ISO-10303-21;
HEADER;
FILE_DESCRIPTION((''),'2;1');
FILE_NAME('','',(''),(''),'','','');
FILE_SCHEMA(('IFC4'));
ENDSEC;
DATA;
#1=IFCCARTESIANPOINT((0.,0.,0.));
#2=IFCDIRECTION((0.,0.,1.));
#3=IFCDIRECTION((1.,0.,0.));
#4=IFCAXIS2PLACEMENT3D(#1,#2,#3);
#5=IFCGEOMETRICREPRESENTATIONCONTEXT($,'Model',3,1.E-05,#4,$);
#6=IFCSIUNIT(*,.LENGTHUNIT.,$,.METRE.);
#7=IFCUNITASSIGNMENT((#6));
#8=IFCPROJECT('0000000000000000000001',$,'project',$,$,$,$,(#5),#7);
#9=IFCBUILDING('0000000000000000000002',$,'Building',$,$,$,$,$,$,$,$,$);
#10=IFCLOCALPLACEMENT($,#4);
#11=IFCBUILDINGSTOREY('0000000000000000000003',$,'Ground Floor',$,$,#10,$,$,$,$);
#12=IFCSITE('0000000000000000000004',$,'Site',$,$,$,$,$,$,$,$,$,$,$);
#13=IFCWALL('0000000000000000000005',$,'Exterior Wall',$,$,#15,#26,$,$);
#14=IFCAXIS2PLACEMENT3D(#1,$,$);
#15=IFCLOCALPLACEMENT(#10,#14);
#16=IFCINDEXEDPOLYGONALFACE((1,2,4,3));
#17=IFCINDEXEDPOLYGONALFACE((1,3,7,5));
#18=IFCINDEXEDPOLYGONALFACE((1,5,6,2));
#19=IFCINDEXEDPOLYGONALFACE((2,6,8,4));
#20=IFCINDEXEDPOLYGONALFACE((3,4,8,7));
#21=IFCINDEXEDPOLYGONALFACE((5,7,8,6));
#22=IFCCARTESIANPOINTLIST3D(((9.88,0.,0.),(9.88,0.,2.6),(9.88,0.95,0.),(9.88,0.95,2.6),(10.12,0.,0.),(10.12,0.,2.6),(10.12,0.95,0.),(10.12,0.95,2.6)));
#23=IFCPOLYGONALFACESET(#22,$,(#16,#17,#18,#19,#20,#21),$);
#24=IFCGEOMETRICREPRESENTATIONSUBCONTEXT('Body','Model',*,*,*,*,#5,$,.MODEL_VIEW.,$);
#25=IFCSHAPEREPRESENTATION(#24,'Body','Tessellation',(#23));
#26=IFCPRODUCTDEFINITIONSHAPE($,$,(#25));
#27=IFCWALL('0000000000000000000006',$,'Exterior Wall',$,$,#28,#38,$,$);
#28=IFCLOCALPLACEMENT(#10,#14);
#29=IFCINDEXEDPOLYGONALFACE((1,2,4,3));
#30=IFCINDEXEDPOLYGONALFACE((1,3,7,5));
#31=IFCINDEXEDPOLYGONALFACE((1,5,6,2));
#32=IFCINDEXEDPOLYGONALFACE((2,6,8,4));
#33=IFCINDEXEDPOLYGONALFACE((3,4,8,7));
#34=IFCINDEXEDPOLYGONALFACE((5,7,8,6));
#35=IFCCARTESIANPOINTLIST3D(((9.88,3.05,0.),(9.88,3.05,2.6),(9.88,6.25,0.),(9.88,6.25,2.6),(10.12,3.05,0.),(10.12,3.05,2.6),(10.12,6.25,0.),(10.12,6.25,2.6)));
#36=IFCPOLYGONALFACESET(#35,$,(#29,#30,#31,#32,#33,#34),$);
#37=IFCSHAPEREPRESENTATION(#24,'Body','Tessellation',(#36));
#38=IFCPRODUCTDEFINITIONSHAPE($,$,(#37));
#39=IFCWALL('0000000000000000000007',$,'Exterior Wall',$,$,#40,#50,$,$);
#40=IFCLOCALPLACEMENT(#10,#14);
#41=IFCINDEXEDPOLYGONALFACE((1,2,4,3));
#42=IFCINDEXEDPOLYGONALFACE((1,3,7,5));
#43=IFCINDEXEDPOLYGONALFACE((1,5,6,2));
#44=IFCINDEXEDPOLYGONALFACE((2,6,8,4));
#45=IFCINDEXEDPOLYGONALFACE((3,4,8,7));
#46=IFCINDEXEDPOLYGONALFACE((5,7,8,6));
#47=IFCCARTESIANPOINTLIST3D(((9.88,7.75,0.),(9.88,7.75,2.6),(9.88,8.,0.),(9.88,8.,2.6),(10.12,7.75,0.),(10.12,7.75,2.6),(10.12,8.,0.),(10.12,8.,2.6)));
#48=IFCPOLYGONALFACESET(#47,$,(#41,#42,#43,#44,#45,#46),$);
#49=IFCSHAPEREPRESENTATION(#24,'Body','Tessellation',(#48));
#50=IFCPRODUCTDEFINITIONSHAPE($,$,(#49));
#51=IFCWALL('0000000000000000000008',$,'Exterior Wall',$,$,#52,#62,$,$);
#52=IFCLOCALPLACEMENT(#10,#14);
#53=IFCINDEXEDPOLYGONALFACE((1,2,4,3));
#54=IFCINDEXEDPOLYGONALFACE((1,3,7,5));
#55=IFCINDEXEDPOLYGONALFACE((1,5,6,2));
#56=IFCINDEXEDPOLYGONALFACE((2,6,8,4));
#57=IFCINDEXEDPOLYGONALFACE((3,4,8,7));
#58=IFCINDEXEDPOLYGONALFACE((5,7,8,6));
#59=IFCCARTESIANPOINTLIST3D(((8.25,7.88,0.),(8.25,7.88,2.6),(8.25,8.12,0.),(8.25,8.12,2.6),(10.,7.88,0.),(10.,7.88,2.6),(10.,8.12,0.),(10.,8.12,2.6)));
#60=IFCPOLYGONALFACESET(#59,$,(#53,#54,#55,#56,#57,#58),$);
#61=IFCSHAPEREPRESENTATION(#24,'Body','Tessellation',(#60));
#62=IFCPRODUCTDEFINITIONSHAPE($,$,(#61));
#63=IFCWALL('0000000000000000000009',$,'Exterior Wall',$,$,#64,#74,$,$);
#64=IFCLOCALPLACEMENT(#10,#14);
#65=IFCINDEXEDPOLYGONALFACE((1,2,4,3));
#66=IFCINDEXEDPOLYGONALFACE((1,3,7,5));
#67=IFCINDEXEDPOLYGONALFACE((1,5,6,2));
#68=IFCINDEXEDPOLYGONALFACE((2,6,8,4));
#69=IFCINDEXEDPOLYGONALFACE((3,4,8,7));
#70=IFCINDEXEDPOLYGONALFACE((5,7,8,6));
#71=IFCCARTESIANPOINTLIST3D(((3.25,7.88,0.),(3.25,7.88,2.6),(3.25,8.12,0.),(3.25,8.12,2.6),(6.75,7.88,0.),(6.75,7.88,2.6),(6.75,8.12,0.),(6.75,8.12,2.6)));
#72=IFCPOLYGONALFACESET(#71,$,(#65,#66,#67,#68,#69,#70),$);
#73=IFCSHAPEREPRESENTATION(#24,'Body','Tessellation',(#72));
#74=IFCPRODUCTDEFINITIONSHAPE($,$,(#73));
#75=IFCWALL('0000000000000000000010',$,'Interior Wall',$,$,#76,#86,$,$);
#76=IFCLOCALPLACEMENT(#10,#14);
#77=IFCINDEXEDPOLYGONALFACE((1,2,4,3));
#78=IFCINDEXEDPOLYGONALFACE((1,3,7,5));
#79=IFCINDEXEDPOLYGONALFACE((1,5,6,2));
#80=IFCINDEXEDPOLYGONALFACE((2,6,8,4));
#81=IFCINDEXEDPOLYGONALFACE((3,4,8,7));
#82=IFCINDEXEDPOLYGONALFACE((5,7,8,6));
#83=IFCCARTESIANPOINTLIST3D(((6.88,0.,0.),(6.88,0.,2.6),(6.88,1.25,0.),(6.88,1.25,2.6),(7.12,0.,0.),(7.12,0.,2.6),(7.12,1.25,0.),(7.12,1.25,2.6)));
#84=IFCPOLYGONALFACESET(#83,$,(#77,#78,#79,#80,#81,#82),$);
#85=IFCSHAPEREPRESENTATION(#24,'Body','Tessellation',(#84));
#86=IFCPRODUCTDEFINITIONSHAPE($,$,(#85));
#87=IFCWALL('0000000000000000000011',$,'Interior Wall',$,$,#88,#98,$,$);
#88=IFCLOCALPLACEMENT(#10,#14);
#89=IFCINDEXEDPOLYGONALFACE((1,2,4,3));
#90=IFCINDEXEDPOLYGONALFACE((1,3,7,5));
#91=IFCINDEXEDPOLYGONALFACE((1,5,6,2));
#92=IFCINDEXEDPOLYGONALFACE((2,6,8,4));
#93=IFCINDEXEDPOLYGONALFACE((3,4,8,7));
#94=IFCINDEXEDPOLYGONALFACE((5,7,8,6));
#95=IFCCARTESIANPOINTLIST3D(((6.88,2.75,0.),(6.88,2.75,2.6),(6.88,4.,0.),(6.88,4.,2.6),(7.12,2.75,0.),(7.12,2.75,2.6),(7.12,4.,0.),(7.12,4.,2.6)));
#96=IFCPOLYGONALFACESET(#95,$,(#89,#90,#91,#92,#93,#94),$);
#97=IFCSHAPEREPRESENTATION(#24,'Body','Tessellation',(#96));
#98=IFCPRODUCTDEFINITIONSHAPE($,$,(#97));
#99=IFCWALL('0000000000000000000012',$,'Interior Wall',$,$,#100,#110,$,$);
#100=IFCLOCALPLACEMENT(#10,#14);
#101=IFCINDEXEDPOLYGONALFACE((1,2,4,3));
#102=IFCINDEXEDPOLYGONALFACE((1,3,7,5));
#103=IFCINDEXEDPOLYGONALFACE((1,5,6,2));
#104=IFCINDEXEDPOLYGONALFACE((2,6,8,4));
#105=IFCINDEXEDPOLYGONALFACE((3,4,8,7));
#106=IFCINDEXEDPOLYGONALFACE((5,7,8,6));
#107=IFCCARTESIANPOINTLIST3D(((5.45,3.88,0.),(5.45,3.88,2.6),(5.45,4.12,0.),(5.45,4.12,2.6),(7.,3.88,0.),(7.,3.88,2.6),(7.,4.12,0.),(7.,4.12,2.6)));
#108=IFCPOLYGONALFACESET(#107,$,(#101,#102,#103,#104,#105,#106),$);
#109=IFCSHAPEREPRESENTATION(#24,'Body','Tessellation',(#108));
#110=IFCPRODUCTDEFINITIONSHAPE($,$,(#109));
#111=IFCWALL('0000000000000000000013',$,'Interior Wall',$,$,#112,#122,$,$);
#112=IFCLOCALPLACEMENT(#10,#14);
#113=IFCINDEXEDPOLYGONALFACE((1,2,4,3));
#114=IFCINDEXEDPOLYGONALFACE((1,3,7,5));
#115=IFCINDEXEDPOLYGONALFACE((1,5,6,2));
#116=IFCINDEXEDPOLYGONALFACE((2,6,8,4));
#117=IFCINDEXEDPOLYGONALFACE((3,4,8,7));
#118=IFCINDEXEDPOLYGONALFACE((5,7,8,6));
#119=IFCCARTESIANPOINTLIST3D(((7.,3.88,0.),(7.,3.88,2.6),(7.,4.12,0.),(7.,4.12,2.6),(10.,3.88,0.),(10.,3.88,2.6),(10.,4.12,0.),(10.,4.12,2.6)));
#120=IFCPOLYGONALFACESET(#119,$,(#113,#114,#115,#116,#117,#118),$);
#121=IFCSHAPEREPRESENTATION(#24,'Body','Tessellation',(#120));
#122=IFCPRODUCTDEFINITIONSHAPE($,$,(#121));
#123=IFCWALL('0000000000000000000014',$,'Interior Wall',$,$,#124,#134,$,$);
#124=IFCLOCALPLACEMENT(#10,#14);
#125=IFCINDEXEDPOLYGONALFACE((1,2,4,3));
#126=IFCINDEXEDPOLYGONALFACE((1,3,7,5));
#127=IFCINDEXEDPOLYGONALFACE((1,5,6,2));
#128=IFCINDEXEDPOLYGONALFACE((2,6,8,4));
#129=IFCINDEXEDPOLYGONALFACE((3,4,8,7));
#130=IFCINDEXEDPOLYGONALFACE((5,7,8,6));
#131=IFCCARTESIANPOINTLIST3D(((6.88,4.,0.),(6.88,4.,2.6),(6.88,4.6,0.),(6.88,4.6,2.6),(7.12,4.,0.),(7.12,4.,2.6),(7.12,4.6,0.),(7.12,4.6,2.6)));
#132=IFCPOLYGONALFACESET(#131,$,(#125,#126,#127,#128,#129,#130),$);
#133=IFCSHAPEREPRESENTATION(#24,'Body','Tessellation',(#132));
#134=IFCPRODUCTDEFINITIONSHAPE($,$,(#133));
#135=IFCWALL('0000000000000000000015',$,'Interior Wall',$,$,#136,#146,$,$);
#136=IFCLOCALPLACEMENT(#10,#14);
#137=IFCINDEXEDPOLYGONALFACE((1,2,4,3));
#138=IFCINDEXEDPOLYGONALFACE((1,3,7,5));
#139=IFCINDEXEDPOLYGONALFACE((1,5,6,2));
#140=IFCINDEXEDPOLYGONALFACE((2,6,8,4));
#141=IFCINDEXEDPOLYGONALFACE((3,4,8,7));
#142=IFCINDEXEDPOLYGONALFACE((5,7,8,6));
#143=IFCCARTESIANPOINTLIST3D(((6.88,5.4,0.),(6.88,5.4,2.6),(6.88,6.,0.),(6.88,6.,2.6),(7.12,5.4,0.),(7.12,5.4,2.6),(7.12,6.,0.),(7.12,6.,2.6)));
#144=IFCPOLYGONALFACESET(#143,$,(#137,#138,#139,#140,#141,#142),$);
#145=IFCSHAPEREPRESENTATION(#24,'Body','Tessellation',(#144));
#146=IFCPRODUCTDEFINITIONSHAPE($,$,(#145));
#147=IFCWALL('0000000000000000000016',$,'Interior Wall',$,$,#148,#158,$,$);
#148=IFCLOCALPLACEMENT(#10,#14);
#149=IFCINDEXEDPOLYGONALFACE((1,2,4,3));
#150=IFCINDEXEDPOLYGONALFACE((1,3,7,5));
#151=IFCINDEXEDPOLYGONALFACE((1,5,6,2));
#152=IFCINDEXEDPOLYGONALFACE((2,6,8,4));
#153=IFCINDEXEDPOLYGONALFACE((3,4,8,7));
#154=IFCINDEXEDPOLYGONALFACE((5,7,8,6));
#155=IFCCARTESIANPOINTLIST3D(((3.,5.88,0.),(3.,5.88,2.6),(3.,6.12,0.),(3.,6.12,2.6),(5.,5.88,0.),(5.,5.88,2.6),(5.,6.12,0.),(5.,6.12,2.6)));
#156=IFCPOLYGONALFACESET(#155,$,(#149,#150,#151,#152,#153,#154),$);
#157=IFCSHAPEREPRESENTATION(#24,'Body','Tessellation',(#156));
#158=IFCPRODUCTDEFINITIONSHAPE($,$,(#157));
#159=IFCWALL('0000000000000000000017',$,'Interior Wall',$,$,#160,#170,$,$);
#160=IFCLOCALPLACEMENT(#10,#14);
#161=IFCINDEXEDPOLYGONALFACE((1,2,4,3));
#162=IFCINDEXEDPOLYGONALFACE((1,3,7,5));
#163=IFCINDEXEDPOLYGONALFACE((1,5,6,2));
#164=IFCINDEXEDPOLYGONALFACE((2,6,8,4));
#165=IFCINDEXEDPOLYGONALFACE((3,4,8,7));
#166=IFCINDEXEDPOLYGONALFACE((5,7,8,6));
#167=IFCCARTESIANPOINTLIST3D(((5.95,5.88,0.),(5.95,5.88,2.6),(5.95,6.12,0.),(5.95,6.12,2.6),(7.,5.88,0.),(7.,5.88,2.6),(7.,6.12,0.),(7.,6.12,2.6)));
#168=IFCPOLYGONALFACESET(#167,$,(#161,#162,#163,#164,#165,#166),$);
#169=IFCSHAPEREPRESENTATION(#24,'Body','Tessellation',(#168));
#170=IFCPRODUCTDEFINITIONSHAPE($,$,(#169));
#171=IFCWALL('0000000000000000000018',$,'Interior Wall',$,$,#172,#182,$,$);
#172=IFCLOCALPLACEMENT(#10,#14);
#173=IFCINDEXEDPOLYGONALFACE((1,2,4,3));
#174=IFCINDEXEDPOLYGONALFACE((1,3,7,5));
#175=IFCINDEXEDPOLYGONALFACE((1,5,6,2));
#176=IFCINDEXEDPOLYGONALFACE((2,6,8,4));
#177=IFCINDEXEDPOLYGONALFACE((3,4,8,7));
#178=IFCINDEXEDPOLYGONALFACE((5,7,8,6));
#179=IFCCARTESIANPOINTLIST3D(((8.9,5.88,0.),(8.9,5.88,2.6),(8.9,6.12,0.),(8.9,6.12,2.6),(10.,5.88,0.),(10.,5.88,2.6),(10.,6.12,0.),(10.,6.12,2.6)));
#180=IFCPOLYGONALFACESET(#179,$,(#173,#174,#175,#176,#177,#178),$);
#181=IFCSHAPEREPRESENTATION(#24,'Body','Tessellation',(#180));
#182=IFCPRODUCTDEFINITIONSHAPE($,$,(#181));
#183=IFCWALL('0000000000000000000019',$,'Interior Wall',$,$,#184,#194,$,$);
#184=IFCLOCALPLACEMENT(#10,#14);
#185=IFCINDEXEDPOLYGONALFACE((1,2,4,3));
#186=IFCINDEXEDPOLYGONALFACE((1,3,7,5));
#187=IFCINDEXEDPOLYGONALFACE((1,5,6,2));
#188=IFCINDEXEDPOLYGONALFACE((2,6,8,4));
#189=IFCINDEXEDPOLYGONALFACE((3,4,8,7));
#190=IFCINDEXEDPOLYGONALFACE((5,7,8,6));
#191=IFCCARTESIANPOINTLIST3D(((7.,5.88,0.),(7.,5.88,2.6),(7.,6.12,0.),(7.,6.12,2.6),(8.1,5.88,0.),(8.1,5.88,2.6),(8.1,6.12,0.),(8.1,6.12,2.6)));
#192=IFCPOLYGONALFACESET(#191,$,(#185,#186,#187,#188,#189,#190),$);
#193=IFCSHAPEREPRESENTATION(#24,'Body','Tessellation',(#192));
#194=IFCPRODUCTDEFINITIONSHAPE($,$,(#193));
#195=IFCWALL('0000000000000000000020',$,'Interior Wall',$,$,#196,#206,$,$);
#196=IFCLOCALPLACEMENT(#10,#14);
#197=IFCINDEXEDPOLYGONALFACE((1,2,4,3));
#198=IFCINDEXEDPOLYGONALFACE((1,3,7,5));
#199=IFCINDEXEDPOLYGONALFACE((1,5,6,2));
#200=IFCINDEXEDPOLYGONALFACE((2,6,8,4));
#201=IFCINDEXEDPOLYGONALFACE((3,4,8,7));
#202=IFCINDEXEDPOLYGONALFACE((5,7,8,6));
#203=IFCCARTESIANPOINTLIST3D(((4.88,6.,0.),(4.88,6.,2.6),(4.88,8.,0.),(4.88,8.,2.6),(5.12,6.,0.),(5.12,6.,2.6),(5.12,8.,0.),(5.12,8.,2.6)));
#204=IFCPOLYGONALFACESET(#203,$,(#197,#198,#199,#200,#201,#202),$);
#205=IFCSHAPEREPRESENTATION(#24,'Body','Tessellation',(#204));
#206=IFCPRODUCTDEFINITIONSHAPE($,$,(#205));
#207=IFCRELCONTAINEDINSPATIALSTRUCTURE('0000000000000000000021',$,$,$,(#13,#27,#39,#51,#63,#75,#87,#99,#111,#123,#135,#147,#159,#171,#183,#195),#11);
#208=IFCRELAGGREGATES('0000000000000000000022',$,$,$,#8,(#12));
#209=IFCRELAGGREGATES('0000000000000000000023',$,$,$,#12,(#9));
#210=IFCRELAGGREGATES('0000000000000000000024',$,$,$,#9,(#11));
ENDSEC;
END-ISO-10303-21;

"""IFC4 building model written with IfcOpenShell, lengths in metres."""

from ifc_helpers import new_model, si_unit, frame, origin_with_axes, place, context, subcontext, project, spatial, indexed_curve, outline, extrude, element, save


model = new_model("IFC4")

# Units and contexts
model_context = context("Model", 3, precision=1e-05, world=origin_with_axes())
body_context = subcontext(model_context, "Body", "Model", "MODEL_VIEW")
ifc_project = project(units=[si_unit("LENGTHUNIT", "METRE")], contexts=[model_context])

# Site, building, storey
site = spatial("IfcSite", under=ifc_project, Name="Site")
building = spatial("IfcBuilding", under=site, Name="Building")
storey_placement = place(None, origin_with_axes())
storey = spatial("IfcBuildingStorey", under=building, at=storey_placement, Name="Ground Floor")

# Walls
wall_1_placement = place(storey_placement, frame((10.0, 0.0, 0.0), z_axis=(0.0, 0.0, 1.0), x_axis=(0.0, 1.0, 0.0)))
element("IfcWall", 1, at=wall_1_placement, inside=storey, Name="Exterior Wall", context=body_context, shape_type="SweptSolid", body=[
    extrude(outline(indexed_curve([(0.0, 0.0), (0.0, 0.24), (0.95, 0.24), (0.95, 0.0), (0.0, 0.0)], self_intersect=False)), frame((0.0, -0.12, 0.0), z_axis=(0.0, 0.0, 1.0), x_axis=(1.0, 0.0, 0.0)), (0.0, 0.0, 1.0), 2.6),
])
wall_2_placement = place(storey_placement, frame((10.0, 3.05, 0.0), z_axis=(0.0, 0.0, 1.0), x_axis=(0.0, 1.0, 0.0)))
element("IfcWall", 2, at=wall_2_placement, inside=storey, Name="Exterior Wall", context=body_context, shape_type="SweptSolid", body=[
    extrude(outline(indexed_curve([(0.0, 0.0), (0.0, 0.24), (3.2, 0.24), (3.2, 0.0), (0.0, 0.0)], self_intersect=False)), frame((0.0, -0.12, 0.0), z_axis=(0.0, 0.0, 1.0), x_axis=(1.0, 0.0, 0.0)), (0.0, 0.0, 1.0), 2.6),
])
wall_3_placement = place(storey_placement, frame((10.0, 7.75, 0.0), z_axis=(0.0, 0.0, 1.0), x_axis=(0.0, 1.0, 0.0)))
element("IfcWall", 3, at=wall_3_placement, inside=storey, Name="Exterior Wall", context=body_context, shape_type="SweptSolid", body=[
    extrude(outline(indexed_curve([(0.0, 0.0), (0.0, 0.24), (0.25, 0.24), (0.25, 0.0), (0.0, 0.0)], self_intersect=False)), frame((0.0, -0.12, 0.0), z_axis=(0.0, 0.0, 1.0), x_axis=(1.0, 0.0, 0.0)), (0.0, 0.0, 1.0), 2.6),
])
wall_4_placement = place(storey_placement, frame((10.0, 8.0, 0.0), z_axis=(0.0, 0.0, 1.0), x_axis=(-1.0, 0.0, 0.0)))
element("IfcWall", 4, at=wall_4_placement, inside=storey, Name="Exterior Wall", context=body_context, shape_type="SweptSolid", body=[
    extrude(outline(indexed_curve([(0.0, 0.0), (0.0, 0.24), (1.75, 0.24), (1.75, 0.0), (0.0, 0.0)], self_intersect=False)), frame((0.0, -0.12, 0.0), z_axis=(0.0, 0.0, 1.0), x_axis=(1.0, 0.0, 0.0)), (0.0, 0.0, 1.0), 2.6),
])
wall_5_placement = place(storey_placement, frame((6.75, 8.0, 0.0), z_axis=(0.0, 0.0, 1.0), x_axis=(-1.0, 0.0, 0.0)))
element("IfcWall", 5, at=wall_5_placement, inside=storey, Name="Exterior Wall", context=body_context, shape_type="SweptSolid", body=[
    extrude(outline(indexed_curve([(0.0, 0.0), (0.0, 0.24), (3.5, 0.24), (3.5, 0.0), (0.0, 0.0)], self_intersect=False)), frame((0.0, -0.12, 0.0), z_axis=(0.0, 0.0, 1.0), x_axis=(1.0, 0.0, 0.0)), (0.0, 0.0, 1.0), 2.6),
])
for number, where, z_axis, x_axis, name in (
    (6, (7.0, 0.0, 0.0), (0.0, 0.0, 1.0), (0.0, 1.0, 0.0), "Interior Wall"),
    (7, (7.0, 2.75, 0.0), (0.0, 0.0, 1.0), (0.0, 1.0, 0.0), "Interior Wall"),
):
    element("IfcWall", number, at=place(storey_placement, frame(where, z_axis=z_axis, x_axis=x_axis)), inside=storey, Name=name, context=body_context, shape_type="SweptSolid", body=[
        extrude(outline(indexed_curve([(0.0, 0.0), (0.0, 0.24), (1.25, 0.24), (1.25, 0.0), (0.0, 0.0)], self_intersect=False)), frame((0.0, -0.12, 0.0), z_axis=(0.0, 0.0, 1.0), x_axis=(1.0, 0.0, 0.0)), (0.0, 0.0, 1.0), 2.6),
    ])
wall_6_placement = place(storey_placement, frame((7.0, 4.0, 0.0), z_axis=(0.0, 0.0, 1.0), x_axis=(-1.0, 0.0, 0.0)))
element("IfcWall", 8, at=wall_6_placement, inside=storey, Name="Interior Wall", context=body_context, shape_type="SweptSolid", body=[
    extrude(outline(indexed_curve([(0.0, 0.0), (0.0, 0.24), (1.55, 0.24), (1.55, 0.0), (0.0, 0.0)], self_intersect=False)), frame((0.0, -0.12, 0.0), z_axis=(0.0, 0.0, 1.0), x_axis=(1.0, 0.0, 0.0)), (0.0, 0.0, 1.0), 2.6),
])
wall_7_placement = place(storey_placement, frame((10.0, 4.0, 0.0), z_axis=(0.0, 0.0, 1.0), x_axis=(-1.0, 0.0, 0.0)))
element("IfcWall", 9, at=wall_7_placement, inside=storey, Name="Interior Wall", context=body_context, shape_type="SweptSolid", body=[
    extrude(outline(indexed_curve([(0.0, 0.0), (0.0, 0.24), (3.0, 0.24), (3.0, 0.0), (0.0, 0.0)], self_intersect=False)), frame((0.0, -0.12, 0.0), z_axis=(0.0, 0.0, 1.0), x_axis=(1.0, 0.0, 0.0)), (0.0, 0.0, 1.0), 2.6),
])
for number, where, z_axis, x_axis, name in (
    (10, (7.0, 4.0, 0.0), (0.0, 0.0, 1.0), (0.0, 1.0, 0.0), "Interior Wall"),
    (11, (7.0, 5.4, 0.0), (0.0, 0.0, 1.0), (0.0, 1.0, 0.0), "Interior Wall"),
):
    element("IfcWall", number, at=place(storey_placement, frame(where, z_axis=z_axis, x_axis=x_axis)), inside=storey, Name=name, context=body_context, shape_type="SweptSolid", body=[
        extrude(outline(indexed_curve([(0.0, 0.0), (0.0, 0.24), (0.6, 0.24), (0.6, 0.0), (0.0, 0.0)], self_intersect=False)), frame((0.0, -0.12, 0.0), z_axis=(0.0, 0.0, 1.0), x_axis=(1.0, 0.0, 0.0)), (0.0, 0.0, 1.0), 2.6),
    ])
wall_8_placement = place(storey_placement, frame((5.0, 6.0, 0.0), z_axis=(0.0, 0.0, 1.0), x_axis=(-1.0, 0.0, 0.0)))
element("IfcWall", 12, at=wall_8_placement, inside=storey, Name="Interior Wall", context=body_context, shape_type="SweptSolid", body=[
    extrude(outline(indexed_curve([(0.0, 0.0), (0.0, 0.24), (2.0, 0.24), (2.0, 0.0), (0.0, 0.0)], self_intersect=False)), frame((0.0, -0.12, 0.0), z_axis=(0.0, 0.0, 1.0), x_axis=(1.0, 0.0, 0.0)), (0.0, 0.0, 1.0), 2.6),
])
wall_9_placement = place(storey_placement, frame((7.0, 6.0, 0.0), z_axis=(0.0, 0.0, 1.0), x_axis=(-1.0, 0.0, 0.0)))
element("IfcWall", 13, at=wall_9_placement, inside=storey, Name="Interior Wall", context=body_context, shape_type="SweptSolid", body=[
    extrude(outline(indexed_curve([(0.0, 0.0), (0.0, 0.24), (1.05, 0.24), (1.05, 0.0), (0.0, 0.0)], self_intersect=False)), frame((0.0, -0.12, 0.0), z_axis=(0.0, 0.0, 1.0), x_axis=(1.0, 0.0, 0.0)), (0.0, 0.0, 1.0), 2.6),
])
for number, where, z_axis, x_axis, name in (
    (14, (10.0, 6.0, 0.0), (0.0, 0.0, 1.0), (-1.0, 0.0, 0.0), "Interior Wall"),
    (15, (8.1, 6.0, 0.0), (0.0, 0.0, 1.0), (-1.0, 0.0, 0.0), "Interior Wall"),
):
    element("IfcWall", number, at=place(storey_placement, frame(where, z_axis=z_axis, x_axis=x_axis)), inside=storey, Name=name, context=body_context, shape_type="SweptSolid", body=[
        extrude(outline(indexed_curve([(0.0, 0.0), (0.0, 0.24), (1.1, 0.24), (1.1, 0.0), (0.0, 0.0)], self_intersect=False)), frame((0.0, -0.12, 0.0), z_axis=(0.0, 0.0, 1.0), x_axis=(1.0, 0.0, 0.0)), (0.0, 0.0, 1.0), 2.6),
    ])
wall_10_placement = place(storey_placement, frame((5.0, 6.0, 0.0), z_axis=(0.0, 0.0, 1.0), x_axis=(0.0, 1.0, 0.0)))
element("IfcWall", 16, at=wall_10_placement, inside=storey, Name="Interior Wall", context=body_context, shape_type="SweptSolid", body=[
    extrude(outline(indexed_curve([(0.0, 0.0), (0.0, 0.24), (2.0, 0.24), (2.0, 0.0), (0.0, 0.0)], self_intersect=False)), frame((0.0, -0.12, 0.0), z_axis=(0.0, 0.0, 1.0), x_axis=(1.0, 0.0, 0.0)), (0.0, 0.0, 1.0), 2.6),
])

save(model, "model.ifc")
